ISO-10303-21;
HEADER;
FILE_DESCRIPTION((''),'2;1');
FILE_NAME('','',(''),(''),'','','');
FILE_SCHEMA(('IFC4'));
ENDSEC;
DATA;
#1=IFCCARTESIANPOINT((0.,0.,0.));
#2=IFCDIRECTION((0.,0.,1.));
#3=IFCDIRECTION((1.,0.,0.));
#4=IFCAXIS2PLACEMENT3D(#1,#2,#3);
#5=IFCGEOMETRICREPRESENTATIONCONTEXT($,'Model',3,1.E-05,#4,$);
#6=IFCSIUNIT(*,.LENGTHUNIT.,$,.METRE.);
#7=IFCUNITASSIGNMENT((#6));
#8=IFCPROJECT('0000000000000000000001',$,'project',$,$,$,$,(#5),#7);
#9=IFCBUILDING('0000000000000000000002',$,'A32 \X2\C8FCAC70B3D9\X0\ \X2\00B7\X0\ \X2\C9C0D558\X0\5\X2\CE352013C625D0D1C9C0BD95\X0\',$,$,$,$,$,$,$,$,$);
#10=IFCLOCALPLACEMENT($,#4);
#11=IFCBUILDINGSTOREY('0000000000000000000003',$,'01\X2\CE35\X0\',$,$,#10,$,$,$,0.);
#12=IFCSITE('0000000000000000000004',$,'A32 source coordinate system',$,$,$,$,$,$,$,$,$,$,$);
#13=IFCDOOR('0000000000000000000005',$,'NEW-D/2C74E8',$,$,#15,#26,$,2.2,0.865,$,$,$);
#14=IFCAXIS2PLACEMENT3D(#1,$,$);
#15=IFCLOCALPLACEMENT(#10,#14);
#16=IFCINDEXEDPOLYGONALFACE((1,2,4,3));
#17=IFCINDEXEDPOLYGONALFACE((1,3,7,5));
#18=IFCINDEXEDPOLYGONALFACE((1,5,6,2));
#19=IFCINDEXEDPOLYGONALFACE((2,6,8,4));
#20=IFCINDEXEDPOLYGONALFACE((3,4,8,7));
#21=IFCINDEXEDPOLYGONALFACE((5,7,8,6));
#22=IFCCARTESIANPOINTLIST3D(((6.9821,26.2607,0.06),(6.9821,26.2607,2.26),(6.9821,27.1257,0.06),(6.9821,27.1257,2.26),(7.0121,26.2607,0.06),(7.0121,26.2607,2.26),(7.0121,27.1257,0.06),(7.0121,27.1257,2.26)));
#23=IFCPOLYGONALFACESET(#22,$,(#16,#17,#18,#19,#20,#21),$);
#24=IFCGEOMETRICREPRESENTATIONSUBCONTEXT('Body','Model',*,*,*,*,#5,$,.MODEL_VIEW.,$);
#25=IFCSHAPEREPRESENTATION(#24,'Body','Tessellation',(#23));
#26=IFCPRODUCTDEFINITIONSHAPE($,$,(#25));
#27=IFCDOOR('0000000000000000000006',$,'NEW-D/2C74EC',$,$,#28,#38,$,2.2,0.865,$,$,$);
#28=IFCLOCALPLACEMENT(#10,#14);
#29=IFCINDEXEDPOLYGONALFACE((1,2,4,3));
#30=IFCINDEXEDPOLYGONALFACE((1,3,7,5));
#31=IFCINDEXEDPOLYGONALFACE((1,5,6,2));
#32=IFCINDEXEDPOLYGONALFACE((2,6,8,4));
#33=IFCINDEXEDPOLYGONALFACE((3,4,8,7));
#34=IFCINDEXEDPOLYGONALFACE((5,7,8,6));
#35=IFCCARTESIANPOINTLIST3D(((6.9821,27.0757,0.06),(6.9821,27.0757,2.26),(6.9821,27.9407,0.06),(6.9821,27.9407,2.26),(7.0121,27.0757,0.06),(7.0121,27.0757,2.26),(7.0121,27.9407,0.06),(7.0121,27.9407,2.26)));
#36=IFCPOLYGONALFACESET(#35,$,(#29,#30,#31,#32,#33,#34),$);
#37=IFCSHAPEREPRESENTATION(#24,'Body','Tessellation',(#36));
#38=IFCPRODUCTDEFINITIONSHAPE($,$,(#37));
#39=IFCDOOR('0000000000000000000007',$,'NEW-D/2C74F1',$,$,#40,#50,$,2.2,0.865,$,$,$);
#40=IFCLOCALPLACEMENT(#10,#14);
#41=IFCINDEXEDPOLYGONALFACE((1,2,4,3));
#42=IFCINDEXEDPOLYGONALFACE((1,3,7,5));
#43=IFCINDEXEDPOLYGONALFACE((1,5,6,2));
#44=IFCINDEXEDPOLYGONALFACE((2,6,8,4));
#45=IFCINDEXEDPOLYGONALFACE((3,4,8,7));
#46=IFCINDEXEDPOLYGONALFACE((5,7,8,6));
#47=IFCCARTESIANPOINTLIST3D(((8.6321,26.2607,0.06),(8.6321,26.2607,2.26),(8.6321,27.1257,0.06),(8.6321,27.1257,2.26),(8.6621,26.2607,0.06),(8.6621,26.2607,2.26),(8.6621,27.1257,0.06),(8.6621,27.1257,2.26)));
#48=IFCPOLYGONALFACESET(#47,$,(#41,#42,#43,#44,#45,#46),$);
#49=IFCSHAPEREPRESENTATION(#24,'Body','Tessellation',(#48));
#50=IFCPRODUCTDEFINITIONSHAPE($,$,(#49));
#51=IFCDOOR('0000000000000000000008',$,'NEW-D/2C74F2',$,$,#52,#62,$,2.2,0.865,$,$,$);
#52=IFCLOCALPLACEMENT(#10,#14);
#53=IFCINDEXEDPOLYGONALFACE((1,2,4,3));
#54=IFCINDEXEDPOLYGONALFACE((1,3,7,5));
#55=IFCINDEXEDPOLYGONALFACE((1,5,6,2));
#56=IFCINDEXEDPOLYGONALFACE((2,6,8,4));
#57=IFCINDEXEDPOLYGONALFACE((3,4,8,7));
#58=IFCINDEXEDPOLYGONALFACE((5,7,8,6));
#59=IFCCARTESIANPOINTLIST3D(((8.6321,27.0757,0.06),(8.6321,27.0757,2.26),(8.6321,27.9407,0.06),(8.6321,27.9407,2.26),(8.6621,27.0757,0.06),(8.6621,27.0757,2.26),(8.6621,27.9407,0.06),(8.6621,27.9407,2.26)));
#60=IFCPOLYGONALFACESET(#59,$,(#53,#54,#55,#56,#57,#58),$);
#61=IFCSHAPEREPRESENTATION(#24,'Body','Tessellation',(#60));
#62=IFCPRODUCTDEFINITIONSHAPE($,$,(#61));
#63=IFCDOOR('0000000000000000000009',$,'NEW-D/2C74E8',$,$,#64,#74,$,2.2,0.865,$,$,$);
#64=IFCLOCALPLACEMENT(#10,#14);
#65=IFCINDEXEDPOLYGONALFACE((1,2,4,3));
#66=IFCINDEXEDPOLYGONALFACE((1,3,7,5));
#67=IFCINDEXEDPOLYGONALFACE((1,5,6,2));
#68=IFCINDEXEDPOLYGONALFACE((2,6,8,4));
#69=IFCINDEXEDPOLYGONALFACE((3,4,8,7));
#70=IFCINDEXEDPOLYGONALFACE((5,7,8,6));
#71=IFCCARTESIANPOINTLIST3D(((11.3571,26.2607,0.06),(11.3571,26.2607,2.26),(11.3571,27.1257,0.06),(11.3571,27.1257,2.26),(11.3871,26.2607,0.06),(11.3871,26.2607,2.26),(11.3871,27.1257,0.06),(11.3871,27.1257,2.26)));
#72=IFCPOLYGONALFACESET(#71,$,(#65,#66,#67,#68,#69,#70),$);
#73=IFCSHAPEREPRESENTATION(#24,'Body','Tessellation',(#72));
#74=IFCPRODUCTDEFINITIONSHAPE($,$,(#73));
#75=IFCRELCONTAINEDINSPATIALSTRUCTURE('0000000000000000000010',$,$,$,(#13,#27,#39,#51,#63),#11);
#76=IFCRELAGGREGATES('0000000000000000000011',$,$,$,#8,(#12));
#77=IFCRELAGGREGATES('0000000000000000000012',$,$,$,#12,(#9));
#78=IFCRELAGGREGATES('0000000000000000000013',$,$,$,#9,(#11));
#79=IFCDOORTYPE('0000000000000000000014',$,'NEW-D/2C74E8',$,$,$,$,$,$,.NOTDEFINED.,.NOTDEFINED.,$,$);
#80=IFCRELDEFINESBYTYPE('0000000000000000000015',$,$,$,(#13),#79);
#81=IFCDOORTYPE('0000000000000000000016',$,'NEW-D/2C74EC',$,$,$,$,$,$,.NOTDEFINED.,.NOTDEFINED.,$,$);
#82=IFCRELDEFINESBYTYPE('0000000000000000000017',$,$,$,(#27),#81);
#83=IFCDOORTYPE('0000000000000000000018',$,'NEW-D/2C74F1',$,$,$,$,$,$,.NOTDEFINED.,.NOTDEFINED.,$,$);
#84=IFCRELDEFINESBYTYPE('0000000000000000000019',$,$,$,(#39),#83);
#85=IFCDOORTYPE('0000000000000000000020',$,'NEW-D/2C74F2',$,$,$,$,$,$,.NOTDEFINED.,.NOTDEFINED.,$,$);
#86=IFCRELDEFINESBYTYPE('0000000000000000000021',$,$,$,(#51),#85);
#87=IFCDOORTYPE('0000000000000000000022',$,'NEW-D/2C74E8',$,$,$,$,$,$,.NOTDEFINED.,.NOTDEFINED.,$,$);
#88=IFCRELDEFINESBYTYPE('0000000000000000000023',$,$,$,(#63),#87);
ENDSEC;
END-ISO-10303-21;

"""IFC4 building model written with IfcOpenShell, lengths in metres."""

from ifc_helpers import new_model, si_unit, frame, origin, origin_with_axes, place, context, subcontext, project, spatial, polyline, outline, extrude, source, transform, mapped, type_object, type_shapes, element, save


model = new_model("IFC4")

# Units and contexts
model_context = context("Model", 3, precision=1e-05, world=origin_with_axes())
body_context = subcontext(model_context, "Body", "Model", "MODEL_VIEW")
ifc_project = project(units=[si_unit("LENGTHUNIT", "METRE")], contexts=[model_context])

# Site, building, storey
site = spatial("IfcSite", under=ifc_project, Name="A32 source coordinate system")
building = spatial("IfcBuilding", under=site, Name="A32 주거동 · 지하5층–옥탑지붕")
storey_placement = place(None, origin_with_axes())
storey = spatial("IfcBuildingStorey", under=building, at=storey_placement, Name="01층", Elevation=0.0)

# Doors
door_type_1 = type_object("IfcDoorType", Name="NEW-D/2C74E8", OperationType="NOTDEFINED", PredefinedType="NOTDEFINED")
shared_shape_1 = source(origin(), body_context, "Body", "SweptSolid", [
    extrude(outline(polyline([(7.0121, 27.1257), (7.0121, 26.2607), (6.9821, 26.2607), (6.9821, 27.1257), (7.0121, 27.1257)])), frame((0.0, 0.0, 0.06)), (0.0, 0.0, 1.0), 2.2),
])
type_shapes(door_type_1, [shared_shape_1])
door_1_placement = place(storey_placement, origin_with_axes())
element("IfcDoor", 1, at=door_1_placement, inside=storey, type_object=door_type_1, Name="NEW-D/2C74E8", OverallHeight=2.2, OverallWidth=0.865, context=body_context, shape_type="MappedRepresentation", body=[
    mapped(shared_shape_1, transform((0.0, 0.0, 0.0), scale=1.0)),
])
door_type_2 = type_object("IfcDoorType", Name="NEW-D/2C74EC", OperationType="NOTDEFINED", PredefinedType="NOTDEFINED")
shared_shape_2 = source(origin(), body_context, "Body", "SweptSolid", [
    extrude(outline(polyline([(6.9821, 27.9407), (7.0121, 27.9407), (7.0121, 27.0757), (6.9821, 27.0757), (6.9821, 27.9407)])), frame((0.0, 0.0, 0.06)), (0.0, 0.0, 1.0), 2.2),
])
type_shapes(door_type_2, [shared_shape_2])
door_2_placement = place(storey_placement, origin_with_axes())
element("IfcDoor", 2, at=door_2_placement, inside=storey, type_object=door_type_2, Name="NEW-D/2C74EC", OverallHeight=2.2, OverallWidth=0.865, context=body_context, shape_type="MappedRepresentation", body=[
    mapped(shared_shape_2, transform((0.0, 0.0, 0.0), scale=1.0)),
])
door_type_3 = type_object("IfcDoorType", Name="NEW-D/2C74F1", OperationType="NOTDEFINED", PredefinedType="NOTDEFINED")
shared_shape_3 = source(origin(), body_context, "Body", "SweptSolid", [
    extrude(outline(polyline([(8.6621, 26.2607), (8.6321, 26.2607), (8.6321, 27.1257), (8.6621, 27.1257), (8.6621, 26.2607)])), frame((0.0, 0.0, 0.06)), (0.0, 0.0, 1.0), 2.2),
])
type_shapes(door_type_3, [shared_shape_3])
door_3_placement = place(storey_placement, origin_with_axes())
element("IfcDoor", 3, at=door_3_placement, inside=storey, type_object=door_type_3, Name="NEW-D/2C74F1", OverallHeight=2.2, OverallWidth=0.865, context=body_context, shape_type="MappedRepresentation", body=[
    mapped(shared_shape_3, transform((0.0, 0.0, 0.0), scale=1.0)),
])
door_type_4 = type_object("IfcDoorType", Name="NEW-D/2C74F2", OperationType="NOTDEFINED", PredefinedType="NOTDEFINED")
shared_shape_4 = source(origin(), body_context, "Body", "SweptSolid", [
    extrude(outline(polyline([(8.6321, 27.0757), (8.6321, 27.9407), (8.6621, 27.9407), (8.6621, 27.0757), (8.6321, 27.0757)])), frame((0.0, 0.0, 0.06)), (0.0, 0.0, 1.0), 2.2),
])
type_shapes(door_type_4, [shared_shape_4])
door_4_placement = place(storey_placement, origin_with_axes())
element("IfcDoor", 4, at=door_4_placement, inside=storey, type_object=door_type_4, Name="NEW-D/2C74F2", OverallHeight=2.2, OverallWidth=0.865, context=body_context, shape_type="MappedRepresentation", body=[
    mapped(shared_shape_4, transform((0.0, 0.0, 0.0), scale=1.0)),
])
door_type_5 = type_object("IfcDoorType", Name="NEW-D/2C74E8", OperationType="NOTDEFINED", PredefinedType="NOTDEFINED")
shared_shape_5 = source(origin(), body_context, "Body", "SweptSolid", [
    extrude(outline(polyline([(11.3871, 27.1257), (11.3871, 26.2607), (11.3571, 26.2607), (11.3571, 27.1257), (11.3871, 27.1257)])), frame((0.0, 0.0, 0.06)), (0.0, 0.0, 1.0), 2.2),
])
type_shapes(door_type_5, [shared_shape_5])
door_5_placement = place(storey_placement, origin_with_axes())
element("IfcDoor", 5, at=door_5_placement, inside=storey, type_object=door_type_5, Name="NEW-D/2C74E8", OverallHeight=2.2, OverallWidth=0.865, context=body_context, shape_type="MappedRepresentation", body=[
    mapped(shared_shape_5, transform((0.0, 0.0, 0.0), scale=1.0)),
])

save(model, "model.ifc")
